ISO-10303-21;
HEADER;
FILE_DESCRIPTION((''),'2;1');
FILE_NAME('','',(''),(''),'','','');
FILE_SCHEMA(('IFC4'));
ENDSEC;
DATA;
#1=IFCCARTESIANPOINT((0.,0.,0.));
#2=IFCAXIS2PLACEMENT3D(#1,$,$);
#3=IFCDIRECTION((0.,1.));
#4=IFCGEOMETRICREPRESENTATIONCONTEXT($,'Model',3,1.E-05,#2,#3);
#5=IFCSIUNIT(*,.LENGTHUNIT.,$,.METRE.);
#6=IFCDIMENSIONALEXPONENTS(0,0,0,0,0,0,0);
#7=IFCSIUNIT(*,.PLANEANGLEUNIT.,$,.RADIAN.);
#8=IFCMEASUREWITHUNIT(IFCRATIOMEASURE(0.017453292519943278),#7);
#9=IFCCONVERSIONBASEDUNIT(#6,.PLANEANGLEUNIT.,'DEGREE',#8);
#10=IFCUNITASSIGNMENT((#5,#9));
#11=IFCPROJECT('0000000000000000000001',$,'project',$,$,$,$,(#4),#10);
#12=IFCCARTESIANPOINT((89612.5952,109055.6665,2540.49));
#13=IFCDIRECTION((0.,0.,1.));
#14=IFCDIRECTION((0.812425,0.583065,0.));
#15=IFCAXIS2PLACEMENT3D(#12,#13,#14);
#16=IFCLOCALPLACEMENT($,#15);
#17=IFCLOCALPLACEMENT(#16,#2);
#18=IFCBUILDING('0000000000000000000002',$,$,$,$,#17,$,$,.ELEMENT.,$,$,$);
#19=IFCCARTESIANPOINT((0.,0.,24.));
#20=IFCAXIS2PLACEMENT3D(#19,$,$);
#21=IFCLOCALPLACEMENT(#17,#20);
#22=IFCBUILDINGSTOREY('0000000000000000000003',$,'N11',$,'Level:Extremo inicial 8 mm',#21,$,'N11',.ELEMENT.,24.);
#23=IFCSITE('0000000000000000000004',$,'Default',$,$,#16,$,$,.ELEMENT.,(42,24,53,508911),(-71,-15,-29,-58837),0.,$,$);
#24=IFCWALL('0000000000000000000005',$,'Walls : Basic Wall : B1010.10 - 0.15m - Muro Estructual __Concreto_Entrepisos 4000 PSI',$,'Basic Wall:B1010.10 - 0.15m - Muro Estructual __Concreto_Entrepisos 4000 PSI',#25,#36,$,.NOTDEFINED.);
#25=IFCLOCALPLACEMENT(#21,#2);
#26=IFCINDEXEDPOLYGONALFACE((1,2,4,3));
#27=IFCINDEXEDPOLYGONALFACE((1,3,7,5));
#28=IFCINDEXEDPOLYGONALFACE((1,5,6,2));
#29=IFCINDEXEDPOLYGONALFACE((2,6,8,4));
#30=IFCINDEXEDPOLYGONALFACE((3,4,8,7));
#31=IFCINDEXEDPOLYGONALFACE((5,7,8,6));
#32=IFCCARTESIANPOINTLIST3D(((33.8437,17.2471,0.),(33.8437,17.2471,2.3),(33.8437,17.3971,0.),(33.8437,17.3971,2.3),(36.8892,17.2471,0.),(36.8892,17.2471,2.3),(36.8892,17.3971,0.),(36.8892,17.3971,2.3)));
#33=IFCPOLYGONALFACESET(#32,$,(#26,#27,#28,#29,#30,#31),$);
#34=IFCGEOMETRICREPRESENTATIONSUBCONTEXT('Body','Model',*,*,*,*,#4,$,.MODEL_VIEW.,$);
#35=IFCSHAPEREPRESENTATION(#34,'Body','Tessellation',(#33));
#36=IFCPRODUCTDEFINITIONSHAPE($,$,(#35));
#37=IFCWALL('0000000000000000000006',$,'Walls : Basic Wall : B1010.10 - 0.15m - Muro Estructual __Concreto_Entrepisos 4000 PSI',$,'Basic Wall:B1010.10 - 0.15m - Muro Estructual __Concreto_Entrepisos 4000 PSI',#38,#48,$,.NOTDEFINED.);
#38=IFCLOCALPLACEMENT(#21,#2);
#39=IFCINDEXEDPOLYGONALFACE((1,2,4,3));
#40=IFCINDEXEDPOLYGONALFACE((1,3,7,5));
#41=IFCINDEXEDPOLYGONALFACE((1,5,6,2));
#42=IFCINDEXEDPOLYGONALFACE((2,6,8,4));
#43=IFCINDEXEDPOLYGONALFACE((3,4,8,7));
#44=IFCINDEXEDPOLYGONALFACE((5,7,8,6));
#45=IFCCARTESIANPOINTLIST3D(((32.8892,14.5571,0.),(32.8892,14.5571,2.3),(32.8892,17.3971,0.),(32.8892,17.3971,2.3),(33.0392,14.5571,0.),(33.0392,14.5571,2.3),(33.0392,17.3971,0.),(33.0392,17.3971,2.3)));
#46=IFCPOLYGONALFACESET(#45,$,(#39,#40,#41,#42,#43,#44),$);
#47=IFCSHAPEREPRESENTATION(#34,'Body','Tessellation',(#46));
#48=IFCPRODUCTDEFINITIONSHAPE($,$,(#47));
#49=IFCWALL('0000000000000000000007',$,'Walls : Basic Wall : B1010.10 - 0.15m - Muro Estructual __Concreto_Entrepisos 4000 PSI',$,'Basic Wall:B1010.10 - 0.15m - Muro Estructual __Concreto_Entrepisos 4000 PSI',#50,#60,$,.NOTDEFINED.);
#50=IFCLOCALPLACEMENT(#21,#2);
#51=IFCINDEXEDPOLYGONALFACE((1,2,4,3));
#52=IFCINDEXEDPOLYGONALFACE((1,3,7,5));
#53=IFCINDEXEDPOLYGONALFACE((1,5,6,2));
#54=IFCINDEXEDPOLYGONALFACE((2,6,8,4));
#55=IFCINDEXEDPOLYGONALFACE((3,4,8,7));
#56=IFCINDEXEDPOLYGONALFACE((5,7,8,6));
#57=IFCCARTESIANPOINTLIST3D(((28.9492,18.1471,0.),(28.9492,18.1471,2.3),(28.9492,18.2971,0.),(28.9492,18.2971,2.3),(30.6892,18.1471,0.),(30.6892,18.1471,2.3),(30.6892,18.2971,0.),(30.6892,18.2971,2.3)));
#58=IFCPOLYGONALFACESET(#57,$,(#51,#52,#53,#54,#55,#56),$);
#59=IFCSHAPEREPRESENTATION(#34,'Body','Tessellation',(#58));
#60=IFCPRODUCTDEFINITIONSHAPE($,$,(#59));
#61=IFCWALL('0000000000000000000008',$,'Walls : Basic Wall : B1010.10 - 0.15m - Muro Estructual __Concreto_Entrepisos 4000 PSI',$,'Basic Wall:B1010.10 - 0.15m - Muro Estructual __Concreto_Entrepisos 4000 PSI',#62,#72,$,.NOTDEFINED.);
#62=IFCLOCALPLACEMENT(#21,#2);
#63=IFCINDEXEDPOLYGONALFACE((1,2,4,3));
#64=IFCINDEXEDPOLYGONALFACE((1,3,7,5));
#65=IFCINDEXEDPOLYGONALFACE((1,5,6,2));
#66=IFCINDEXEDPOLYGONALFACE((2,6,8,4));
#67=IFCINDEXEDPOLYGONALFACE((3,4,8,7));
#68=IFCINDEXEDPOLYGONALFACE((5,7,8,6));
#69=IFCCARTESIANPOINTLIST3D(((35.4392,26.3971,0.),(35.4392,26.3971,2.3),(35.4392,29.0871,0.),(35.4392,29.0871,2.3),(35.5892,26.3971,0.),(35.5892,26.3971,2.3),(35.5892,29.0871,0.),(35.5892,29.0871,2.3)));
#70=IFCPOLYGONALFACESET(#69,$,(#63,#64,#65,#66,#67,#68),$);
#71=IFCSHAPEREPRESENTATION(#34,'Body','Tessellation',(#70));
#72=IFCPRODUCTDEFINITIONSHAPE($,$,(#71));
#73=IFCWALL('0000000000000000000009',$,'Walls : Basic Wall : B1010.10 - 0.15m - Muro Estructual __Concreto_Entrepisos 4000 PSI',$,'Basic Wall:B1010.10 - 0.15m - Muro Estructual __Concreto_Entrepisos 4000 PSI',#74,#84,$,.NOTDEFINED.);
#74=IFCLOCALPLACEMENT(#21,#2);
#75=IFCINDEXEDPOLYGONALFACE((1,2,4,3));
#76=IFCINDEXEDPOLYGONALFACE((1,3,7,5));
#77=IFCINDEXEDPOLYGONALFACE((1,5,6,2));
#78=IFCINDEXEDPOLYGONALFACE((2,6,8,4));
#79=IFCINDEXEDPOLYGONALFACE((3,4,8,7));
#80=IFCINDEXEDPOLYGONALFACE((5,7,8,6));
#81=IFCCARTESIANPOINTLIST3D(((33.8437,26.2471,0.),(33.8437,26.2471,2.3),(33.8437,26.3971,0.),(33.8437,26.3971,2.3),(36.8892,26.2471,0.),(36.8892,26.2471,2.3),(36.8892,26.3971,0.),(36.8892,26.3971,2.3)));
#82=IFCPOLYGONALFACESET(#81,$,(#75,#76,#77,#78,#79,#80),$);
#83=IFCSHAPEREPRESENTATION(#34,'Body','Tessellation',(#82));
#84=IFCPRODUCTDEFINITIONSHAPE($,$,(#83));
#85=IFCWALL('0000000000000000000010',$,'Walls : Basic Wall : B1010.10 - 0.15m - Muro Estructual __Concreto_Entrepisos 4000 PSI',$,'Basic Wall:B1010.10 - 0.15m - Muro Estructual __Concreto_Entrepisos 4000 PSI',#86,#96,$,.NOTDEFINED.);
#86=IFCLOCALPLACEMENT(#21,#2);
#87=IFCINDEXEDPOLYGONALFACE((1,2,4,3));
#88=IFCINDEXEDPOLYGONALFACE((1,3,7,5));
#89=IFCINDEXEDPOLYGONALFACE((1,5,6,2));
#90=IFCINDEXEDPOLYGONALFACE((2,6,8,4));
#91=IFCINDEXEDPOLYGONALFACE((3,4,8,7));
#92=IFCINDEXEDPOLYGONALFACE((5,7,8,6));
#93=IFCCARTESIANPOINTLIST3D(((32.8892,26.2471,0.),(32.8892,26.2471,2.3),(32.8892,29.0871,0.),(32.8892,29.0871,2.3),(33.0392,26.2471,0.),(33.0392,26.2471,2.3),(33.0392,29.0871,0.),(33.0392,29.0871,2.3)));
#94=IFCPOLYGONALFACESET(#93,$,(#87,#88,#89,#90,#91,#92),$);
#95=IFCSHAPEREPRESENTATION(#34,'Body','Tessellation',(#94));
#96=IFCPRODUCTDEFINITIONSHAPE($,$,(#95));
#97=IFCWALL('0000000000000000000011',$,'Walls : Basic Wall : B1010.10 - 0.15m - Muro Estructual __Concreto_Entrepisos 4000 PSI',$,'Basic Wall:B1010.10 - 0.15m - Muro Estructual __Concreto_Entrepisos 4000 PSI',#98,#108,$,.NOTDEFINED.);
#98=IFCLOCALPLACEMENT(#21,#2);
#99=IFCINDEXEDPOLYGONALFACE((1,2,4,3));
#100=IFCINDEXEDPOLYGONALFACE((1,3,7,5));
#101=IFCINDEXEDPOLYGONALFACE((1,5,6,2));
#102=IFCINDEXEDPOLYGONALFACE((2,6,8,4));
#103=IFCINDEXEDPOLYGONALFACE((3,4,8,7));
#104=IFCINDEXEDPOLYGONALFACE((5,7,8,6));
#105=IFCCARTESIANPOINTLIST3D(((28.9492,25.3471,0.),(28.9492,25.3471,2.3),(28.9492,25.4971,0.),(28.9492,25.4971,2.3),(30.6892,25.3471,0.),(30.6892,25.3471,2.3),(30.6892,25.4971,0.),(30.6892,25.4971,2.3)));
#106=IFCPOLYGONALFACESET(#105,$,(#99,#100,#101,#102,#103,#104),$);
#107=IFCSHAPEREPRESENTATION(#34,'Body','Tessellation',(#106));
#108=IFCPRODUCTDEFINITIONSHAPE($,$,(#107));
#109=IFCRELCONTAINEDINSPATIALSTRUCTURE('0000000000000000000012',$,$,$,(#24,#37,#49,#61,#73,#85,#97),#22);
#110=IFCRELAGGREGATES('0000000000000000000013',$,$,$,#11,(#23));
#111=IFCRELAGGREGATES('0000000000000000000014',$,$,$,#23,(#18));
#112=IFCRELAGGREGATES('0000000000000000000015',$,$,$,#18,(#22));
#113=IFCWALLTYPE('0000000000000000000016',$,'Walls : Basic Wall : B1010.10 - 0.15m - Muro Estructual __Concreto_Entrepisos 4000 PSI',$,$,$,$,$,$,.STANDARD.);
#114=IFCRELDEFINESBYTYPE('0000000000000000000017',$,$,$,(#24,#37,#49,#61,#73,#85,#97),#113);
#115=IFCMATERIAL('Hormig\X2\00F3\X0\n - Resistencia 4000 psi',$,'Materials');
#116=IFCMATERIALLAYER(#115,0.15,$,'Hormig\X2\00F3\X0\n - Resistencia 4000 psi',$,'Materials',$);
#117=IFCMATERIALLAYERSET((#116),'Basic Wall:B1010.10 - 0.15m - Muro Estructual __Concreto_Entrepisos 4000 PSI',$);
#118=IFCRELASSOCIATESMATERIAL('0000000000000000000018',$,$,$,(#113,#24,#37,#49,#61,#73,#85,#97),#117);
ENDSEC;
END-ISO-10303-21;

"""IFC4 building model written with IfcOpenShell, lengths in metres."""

from ifc_helpers import new_model, entity, si_unit, converted_unit, direction, frame, frame_2d, origin, place, context, subcontext, project, spatial, rectangle, extrude, material, layer, layer_set, layer_usage, type_object, element, save


model = new_model("IFC4")

# Units and contexts
model_context = context("Model", 3, precision=1e-05, world=origin(), true_north=direction((0.0, 1.0)))
body_context = subcontext(model_context, "Body", "Model", "MODEL_VIEW")
ifc_project = project(units=[si_unit("LENGTHUNIT", "METRE"), converted_unit("PLANEANGLEUNIT", "DEGREE", entity("IfcRatioMeasure", 0.017453292519943278), si_unit("PLANEANGLEUNIT", "RADIAN"), dimensions=[0, 0, 0, 0, 0, 0, 0])], contexts=[model_context])

# Site, building, storey
site_placement = place(None, frame((89612.5952, 109055.6665, 2540.49), z_axis=(0.0, 0.0, 1.0), x_axis=(0.812425, 0.583065, 0.0)))
site = spatial("IfcSite", under=ifc_project, at=site_placement, Name="Default", CompositionType="ELEMENT", RefLatitude=(42, 24, 53, 508911), RefLongitude=(-71, -15, -29, -58837), RefElevation=0.0)
building_placement = place(site_placement, origin())
building = spatial("IfcBuilding", under=site, at=building_placement, CompositionType="ELEMENT")
storey_placement = place(building_placement, frame((0.0, 0.0, 24.0)))
storey = spatial("IfcBuildingStorey", under=building, at=storey_placement, Name="N11", ObjectType="Level:Extremo inicial 8 mm", LongName="N11", CompositionType="ELEMENT", Elevation=24.0)

# Walls
ifc_material = material(Name="Hormigón - Resistencia 4000 psi", Category="Materials")
ifc_layer_1 = layer(ifc_material, 0.15, Name="Hormigón - Resistencia 4000 psi", Category="Materials")
ifc_layer_set_1 = layer_set([ifc_layer_1], Name="Basic Wall:B1010.10 - 0.15m - Muro Estructual __Concreto_Entrepisos 4000 PSI")
wall_type_1 = type_object("IfcWallType", Name="Walls : Basic Wall : B1010.10 - 0.15m - Muro Estructual __Concreto_Entrepisos 4000 PSI", PredefinedType="STANDARD", material=ifc_layer_set_1)
ifc_layer_usage_1 = layer_usage(ifc_layer_set_1, "AXIS2", "NEGATIVE", 0.075)
wall_1_placement = place(storey_placement, frame((36.8892, 17.3221, 0.0), z_axis=(0.0, 0.0, 1.0), x_axis=(-1.0, 0.0, 0.0)))
element("IfcWall", 1, at=wall_1_placement, inside=storey, type_object=wall_type_1, material=ifc_layer_usage_1, Name="Walls : Basic Wall : B1010.10 - 0.15m - Muro Estructual __Concreto_Entrepisos 4000 PSI", ObjectType="Basic Wall:B1010.10 - 0.15m - Muro Estructual __Concreto_Entrepisos 4000 PSI", PredefinedType="NOTDEFINED", context=body_context, shape_type="SweptSolid", body=[
    extrude(rectangle(XDim=3.0455, YDim=0.15, at=frame_2d((1.5228, 0.0), x_axis=(-1.0, 0.0))), origin(), (0.0, 0.0, 1.0), 2.3),
])
ifc_layer_usage_2 = layer_usage(ifc_layer_set_1, "AXIS2", "NEGATIVE", 0.075)
wall_2_placement = place(storey_placement, frame((32.9642, 14.5571, 0.0), z_axis=(0.0, 0.0, 1.0), x_axis=(0.0, 1.0, 0.0)))
element("IfcWall", 2, at=wall_2_placement, inside=storey, type_object=wall_type_1, material=ifc_layer_usage_2, Name="Walls : Basic Wall : B1010.10 - 0.15m - Muro Estructual __Concreto_Entrepisos 4000 PSI", ObjectType="Basic Wall:B1010.10 - 0.15m - Muro Estructual __Concreto_Entrepisos 4000 PSI", PredefinedType="NOTDEFINED", context=body_context, shape_type="SweptSolid", body=[
    extrude(rectangle(XDim=2.84, YDim=0.15, at=frame_2d((1.42, 0.0), x_axis=(-1.0, 0.0))), origin(), (0.0, 0.0, 1.0), 2.3),
])
ifc_layer_usage_3 = layer_usage(ifc_layer_set_1, "AXIS2", "NEGATIVE", 0.075)
wall_3_placement = place(storey_placement, frame((30.6892, 18.2221, 0.0), z_axis=(0.0, 0.0, 1.0), x_axis=(-1.0, 0.0, 0.0)))
element("IfcWall", 3, at=wall_3_placement, inside=storey, type_object=wall_type_1, material=ifc_layer_usage_3, Name="Walls : Basic Wall : B1010.10 - 0.15m - Muro Estructual __Concreto_Entrepisos 4000 PSI", ObjectType="Basic Wall:B1010.10 - 0.15m - Muro Estructual __Concreto_Entrepisos 4000 PSI", PredefinedType="NOTDEFINED", context=body_context, shape_type="SweptSolid", body=[
    extrude(rectangle(XDim=1.74, YDim=0.15, at=frame_2d((0.87, 0.0), x_axis=(-1.0, 0.0))), origin(), (0.0, 0.0, 1.0), 2.3),
])
ifc_layer_usage_4 = layer_usage(ifc_layer_set_1, "AXIS2", "POSITIVE", -0.075)
wall_4_placement = place(storey_placement, frame((35.5142, 29.0871, 0.0), z_axis=(0.0, 0.0, 1.0), x_axis=(0.0, -1.0, 0.0)))
element("IfcWall", 4, at=wall_4_placement, inside=storey, type_object=wall_type_1, material=ifc_layer_usage_4, Name="Walls : Basic Wall : B1010.10 - 0.15m - Muro Estructual __Concreto_Entrepisos 4000 PSI", ObjectType="Basic Wall:B1010.10 - 0.15m - Muro Estructual __Concreto_Entrepisos 4000 PSI", PredefinedType="NOTDEFINED", context=body_context, shape_type="SweptSolid", body=[
    extrude(rectangle(XDim=2.69, YDim=0.15, at=frame_2d((1.345, 0.0), x_axis=(-1.0, 0.0))), origin(), (0.0, 0.0, 1.0), 2.3),
])
ifc_layer_usage_5 = layer_usage(ifc_layer_set_1, "AXIS2", "POSITIVE", -0.075)
wall_5_placement = place(storey_placement, frame((36.8892, 26.3221, 0.0), z_axis=(0.0, 0.0, 1.0), x_axis=(-1.0, 0.0, 0.0)))
element("IfcWall", 5, at=wall_5_placement, inside=storey, type_object=wall_type_1, material=ifc_layer_usage_5, Name="Walls : Basic Wall : B1010.10 - 0.15m - Muro Estructual __Concreto_Entrepisos 4000 PSI", ObjectType="Basic Wall:B1010.10 - 0.15m - Muro Estructual __Concreto_Entrepisos 4000 PSI", PredefinedType="NOTDEFINED", context=body_context, shape_type="SweptSolid", body=[
    extrude(rectangle(XDim=3.0455, YDim=0.15, at=frame_2d((1.5228, 0.0), x_axis=(-1.0, 0.0))), origin(), (0.0, 0.0, 1.0), 2.3),
])
ifc_layer_usage_6 = layer_usage(ifc_layer_set_1, "AXIS2", "POSITIVE", -0.075)
wall_6_placement = place(storey_placement, frame((32.9642, 29.0871, 0.0), z_axis=(0.0, 0.0, 1.0), x_axis=(0.0, -1.0, 0.0)))
element("IfcWall", 6, at=wall_6_placement, inside=storey, type_object=wall_type_1, material=ifc_layer_usage_6, Name="Walls : Basic Wall : B1010.10 - 0.15m - Muro Estructual __Concreto_Entrepisos 4000 PSI", ObjectType="Basic Wall:B1010.10 - 0.15m - Muro Estructual __Concreto_Entrepisos 4000 PSI", PredefinedType="NOTDEFINED", context=body_context, shape_type="SweptSolid", body=[
    extrude(rectangle(XDim=2.84, YDim=0.15, at=frame_2d((1.42, 0.0), x_axis=(-1.0, 0.0))), origin(), (0.0, 0.0, 1.0), 2.3),
])
ifc_layer_usage_7 = layer_usage(ifc_layer_set_1, "AXIS2", "POSITIVE", -0.075)
wall_7_placement = place(storey_placement, frame((30.6892, 25.4221, 0.0), z_axis=(0.0, 0.0, 1.0), x_axis=(-1.0, 0.0, 0.0)))
element("IfcWall", 7, at=wall_7_placement, inside=storey, type_object=wall_type_1, material=ifc_layer_usage_7, Name="Walls : Basic Wall : B1010.10 - 0.15m - Muro Estructual __Concreto_Entrepisos 4000 PSI", ObjectType="Basic Wall:B1010.10 - 0.15m - Muro Estructual __Concreto_Entrepisos 4000 PSI", PredefinedType="NOTDEFINED", context=body_context, shape_type="SweptSolid", body=[
    extrude(rectangle(XDim=1.74, YDim=0.15, at=frame_2d((0.87, 0.0), x_axis=(-1.0, 0.0))), origin(), (0.0, 0.0, 1.0), 2.3),
])

save(model, "model.ifc")
